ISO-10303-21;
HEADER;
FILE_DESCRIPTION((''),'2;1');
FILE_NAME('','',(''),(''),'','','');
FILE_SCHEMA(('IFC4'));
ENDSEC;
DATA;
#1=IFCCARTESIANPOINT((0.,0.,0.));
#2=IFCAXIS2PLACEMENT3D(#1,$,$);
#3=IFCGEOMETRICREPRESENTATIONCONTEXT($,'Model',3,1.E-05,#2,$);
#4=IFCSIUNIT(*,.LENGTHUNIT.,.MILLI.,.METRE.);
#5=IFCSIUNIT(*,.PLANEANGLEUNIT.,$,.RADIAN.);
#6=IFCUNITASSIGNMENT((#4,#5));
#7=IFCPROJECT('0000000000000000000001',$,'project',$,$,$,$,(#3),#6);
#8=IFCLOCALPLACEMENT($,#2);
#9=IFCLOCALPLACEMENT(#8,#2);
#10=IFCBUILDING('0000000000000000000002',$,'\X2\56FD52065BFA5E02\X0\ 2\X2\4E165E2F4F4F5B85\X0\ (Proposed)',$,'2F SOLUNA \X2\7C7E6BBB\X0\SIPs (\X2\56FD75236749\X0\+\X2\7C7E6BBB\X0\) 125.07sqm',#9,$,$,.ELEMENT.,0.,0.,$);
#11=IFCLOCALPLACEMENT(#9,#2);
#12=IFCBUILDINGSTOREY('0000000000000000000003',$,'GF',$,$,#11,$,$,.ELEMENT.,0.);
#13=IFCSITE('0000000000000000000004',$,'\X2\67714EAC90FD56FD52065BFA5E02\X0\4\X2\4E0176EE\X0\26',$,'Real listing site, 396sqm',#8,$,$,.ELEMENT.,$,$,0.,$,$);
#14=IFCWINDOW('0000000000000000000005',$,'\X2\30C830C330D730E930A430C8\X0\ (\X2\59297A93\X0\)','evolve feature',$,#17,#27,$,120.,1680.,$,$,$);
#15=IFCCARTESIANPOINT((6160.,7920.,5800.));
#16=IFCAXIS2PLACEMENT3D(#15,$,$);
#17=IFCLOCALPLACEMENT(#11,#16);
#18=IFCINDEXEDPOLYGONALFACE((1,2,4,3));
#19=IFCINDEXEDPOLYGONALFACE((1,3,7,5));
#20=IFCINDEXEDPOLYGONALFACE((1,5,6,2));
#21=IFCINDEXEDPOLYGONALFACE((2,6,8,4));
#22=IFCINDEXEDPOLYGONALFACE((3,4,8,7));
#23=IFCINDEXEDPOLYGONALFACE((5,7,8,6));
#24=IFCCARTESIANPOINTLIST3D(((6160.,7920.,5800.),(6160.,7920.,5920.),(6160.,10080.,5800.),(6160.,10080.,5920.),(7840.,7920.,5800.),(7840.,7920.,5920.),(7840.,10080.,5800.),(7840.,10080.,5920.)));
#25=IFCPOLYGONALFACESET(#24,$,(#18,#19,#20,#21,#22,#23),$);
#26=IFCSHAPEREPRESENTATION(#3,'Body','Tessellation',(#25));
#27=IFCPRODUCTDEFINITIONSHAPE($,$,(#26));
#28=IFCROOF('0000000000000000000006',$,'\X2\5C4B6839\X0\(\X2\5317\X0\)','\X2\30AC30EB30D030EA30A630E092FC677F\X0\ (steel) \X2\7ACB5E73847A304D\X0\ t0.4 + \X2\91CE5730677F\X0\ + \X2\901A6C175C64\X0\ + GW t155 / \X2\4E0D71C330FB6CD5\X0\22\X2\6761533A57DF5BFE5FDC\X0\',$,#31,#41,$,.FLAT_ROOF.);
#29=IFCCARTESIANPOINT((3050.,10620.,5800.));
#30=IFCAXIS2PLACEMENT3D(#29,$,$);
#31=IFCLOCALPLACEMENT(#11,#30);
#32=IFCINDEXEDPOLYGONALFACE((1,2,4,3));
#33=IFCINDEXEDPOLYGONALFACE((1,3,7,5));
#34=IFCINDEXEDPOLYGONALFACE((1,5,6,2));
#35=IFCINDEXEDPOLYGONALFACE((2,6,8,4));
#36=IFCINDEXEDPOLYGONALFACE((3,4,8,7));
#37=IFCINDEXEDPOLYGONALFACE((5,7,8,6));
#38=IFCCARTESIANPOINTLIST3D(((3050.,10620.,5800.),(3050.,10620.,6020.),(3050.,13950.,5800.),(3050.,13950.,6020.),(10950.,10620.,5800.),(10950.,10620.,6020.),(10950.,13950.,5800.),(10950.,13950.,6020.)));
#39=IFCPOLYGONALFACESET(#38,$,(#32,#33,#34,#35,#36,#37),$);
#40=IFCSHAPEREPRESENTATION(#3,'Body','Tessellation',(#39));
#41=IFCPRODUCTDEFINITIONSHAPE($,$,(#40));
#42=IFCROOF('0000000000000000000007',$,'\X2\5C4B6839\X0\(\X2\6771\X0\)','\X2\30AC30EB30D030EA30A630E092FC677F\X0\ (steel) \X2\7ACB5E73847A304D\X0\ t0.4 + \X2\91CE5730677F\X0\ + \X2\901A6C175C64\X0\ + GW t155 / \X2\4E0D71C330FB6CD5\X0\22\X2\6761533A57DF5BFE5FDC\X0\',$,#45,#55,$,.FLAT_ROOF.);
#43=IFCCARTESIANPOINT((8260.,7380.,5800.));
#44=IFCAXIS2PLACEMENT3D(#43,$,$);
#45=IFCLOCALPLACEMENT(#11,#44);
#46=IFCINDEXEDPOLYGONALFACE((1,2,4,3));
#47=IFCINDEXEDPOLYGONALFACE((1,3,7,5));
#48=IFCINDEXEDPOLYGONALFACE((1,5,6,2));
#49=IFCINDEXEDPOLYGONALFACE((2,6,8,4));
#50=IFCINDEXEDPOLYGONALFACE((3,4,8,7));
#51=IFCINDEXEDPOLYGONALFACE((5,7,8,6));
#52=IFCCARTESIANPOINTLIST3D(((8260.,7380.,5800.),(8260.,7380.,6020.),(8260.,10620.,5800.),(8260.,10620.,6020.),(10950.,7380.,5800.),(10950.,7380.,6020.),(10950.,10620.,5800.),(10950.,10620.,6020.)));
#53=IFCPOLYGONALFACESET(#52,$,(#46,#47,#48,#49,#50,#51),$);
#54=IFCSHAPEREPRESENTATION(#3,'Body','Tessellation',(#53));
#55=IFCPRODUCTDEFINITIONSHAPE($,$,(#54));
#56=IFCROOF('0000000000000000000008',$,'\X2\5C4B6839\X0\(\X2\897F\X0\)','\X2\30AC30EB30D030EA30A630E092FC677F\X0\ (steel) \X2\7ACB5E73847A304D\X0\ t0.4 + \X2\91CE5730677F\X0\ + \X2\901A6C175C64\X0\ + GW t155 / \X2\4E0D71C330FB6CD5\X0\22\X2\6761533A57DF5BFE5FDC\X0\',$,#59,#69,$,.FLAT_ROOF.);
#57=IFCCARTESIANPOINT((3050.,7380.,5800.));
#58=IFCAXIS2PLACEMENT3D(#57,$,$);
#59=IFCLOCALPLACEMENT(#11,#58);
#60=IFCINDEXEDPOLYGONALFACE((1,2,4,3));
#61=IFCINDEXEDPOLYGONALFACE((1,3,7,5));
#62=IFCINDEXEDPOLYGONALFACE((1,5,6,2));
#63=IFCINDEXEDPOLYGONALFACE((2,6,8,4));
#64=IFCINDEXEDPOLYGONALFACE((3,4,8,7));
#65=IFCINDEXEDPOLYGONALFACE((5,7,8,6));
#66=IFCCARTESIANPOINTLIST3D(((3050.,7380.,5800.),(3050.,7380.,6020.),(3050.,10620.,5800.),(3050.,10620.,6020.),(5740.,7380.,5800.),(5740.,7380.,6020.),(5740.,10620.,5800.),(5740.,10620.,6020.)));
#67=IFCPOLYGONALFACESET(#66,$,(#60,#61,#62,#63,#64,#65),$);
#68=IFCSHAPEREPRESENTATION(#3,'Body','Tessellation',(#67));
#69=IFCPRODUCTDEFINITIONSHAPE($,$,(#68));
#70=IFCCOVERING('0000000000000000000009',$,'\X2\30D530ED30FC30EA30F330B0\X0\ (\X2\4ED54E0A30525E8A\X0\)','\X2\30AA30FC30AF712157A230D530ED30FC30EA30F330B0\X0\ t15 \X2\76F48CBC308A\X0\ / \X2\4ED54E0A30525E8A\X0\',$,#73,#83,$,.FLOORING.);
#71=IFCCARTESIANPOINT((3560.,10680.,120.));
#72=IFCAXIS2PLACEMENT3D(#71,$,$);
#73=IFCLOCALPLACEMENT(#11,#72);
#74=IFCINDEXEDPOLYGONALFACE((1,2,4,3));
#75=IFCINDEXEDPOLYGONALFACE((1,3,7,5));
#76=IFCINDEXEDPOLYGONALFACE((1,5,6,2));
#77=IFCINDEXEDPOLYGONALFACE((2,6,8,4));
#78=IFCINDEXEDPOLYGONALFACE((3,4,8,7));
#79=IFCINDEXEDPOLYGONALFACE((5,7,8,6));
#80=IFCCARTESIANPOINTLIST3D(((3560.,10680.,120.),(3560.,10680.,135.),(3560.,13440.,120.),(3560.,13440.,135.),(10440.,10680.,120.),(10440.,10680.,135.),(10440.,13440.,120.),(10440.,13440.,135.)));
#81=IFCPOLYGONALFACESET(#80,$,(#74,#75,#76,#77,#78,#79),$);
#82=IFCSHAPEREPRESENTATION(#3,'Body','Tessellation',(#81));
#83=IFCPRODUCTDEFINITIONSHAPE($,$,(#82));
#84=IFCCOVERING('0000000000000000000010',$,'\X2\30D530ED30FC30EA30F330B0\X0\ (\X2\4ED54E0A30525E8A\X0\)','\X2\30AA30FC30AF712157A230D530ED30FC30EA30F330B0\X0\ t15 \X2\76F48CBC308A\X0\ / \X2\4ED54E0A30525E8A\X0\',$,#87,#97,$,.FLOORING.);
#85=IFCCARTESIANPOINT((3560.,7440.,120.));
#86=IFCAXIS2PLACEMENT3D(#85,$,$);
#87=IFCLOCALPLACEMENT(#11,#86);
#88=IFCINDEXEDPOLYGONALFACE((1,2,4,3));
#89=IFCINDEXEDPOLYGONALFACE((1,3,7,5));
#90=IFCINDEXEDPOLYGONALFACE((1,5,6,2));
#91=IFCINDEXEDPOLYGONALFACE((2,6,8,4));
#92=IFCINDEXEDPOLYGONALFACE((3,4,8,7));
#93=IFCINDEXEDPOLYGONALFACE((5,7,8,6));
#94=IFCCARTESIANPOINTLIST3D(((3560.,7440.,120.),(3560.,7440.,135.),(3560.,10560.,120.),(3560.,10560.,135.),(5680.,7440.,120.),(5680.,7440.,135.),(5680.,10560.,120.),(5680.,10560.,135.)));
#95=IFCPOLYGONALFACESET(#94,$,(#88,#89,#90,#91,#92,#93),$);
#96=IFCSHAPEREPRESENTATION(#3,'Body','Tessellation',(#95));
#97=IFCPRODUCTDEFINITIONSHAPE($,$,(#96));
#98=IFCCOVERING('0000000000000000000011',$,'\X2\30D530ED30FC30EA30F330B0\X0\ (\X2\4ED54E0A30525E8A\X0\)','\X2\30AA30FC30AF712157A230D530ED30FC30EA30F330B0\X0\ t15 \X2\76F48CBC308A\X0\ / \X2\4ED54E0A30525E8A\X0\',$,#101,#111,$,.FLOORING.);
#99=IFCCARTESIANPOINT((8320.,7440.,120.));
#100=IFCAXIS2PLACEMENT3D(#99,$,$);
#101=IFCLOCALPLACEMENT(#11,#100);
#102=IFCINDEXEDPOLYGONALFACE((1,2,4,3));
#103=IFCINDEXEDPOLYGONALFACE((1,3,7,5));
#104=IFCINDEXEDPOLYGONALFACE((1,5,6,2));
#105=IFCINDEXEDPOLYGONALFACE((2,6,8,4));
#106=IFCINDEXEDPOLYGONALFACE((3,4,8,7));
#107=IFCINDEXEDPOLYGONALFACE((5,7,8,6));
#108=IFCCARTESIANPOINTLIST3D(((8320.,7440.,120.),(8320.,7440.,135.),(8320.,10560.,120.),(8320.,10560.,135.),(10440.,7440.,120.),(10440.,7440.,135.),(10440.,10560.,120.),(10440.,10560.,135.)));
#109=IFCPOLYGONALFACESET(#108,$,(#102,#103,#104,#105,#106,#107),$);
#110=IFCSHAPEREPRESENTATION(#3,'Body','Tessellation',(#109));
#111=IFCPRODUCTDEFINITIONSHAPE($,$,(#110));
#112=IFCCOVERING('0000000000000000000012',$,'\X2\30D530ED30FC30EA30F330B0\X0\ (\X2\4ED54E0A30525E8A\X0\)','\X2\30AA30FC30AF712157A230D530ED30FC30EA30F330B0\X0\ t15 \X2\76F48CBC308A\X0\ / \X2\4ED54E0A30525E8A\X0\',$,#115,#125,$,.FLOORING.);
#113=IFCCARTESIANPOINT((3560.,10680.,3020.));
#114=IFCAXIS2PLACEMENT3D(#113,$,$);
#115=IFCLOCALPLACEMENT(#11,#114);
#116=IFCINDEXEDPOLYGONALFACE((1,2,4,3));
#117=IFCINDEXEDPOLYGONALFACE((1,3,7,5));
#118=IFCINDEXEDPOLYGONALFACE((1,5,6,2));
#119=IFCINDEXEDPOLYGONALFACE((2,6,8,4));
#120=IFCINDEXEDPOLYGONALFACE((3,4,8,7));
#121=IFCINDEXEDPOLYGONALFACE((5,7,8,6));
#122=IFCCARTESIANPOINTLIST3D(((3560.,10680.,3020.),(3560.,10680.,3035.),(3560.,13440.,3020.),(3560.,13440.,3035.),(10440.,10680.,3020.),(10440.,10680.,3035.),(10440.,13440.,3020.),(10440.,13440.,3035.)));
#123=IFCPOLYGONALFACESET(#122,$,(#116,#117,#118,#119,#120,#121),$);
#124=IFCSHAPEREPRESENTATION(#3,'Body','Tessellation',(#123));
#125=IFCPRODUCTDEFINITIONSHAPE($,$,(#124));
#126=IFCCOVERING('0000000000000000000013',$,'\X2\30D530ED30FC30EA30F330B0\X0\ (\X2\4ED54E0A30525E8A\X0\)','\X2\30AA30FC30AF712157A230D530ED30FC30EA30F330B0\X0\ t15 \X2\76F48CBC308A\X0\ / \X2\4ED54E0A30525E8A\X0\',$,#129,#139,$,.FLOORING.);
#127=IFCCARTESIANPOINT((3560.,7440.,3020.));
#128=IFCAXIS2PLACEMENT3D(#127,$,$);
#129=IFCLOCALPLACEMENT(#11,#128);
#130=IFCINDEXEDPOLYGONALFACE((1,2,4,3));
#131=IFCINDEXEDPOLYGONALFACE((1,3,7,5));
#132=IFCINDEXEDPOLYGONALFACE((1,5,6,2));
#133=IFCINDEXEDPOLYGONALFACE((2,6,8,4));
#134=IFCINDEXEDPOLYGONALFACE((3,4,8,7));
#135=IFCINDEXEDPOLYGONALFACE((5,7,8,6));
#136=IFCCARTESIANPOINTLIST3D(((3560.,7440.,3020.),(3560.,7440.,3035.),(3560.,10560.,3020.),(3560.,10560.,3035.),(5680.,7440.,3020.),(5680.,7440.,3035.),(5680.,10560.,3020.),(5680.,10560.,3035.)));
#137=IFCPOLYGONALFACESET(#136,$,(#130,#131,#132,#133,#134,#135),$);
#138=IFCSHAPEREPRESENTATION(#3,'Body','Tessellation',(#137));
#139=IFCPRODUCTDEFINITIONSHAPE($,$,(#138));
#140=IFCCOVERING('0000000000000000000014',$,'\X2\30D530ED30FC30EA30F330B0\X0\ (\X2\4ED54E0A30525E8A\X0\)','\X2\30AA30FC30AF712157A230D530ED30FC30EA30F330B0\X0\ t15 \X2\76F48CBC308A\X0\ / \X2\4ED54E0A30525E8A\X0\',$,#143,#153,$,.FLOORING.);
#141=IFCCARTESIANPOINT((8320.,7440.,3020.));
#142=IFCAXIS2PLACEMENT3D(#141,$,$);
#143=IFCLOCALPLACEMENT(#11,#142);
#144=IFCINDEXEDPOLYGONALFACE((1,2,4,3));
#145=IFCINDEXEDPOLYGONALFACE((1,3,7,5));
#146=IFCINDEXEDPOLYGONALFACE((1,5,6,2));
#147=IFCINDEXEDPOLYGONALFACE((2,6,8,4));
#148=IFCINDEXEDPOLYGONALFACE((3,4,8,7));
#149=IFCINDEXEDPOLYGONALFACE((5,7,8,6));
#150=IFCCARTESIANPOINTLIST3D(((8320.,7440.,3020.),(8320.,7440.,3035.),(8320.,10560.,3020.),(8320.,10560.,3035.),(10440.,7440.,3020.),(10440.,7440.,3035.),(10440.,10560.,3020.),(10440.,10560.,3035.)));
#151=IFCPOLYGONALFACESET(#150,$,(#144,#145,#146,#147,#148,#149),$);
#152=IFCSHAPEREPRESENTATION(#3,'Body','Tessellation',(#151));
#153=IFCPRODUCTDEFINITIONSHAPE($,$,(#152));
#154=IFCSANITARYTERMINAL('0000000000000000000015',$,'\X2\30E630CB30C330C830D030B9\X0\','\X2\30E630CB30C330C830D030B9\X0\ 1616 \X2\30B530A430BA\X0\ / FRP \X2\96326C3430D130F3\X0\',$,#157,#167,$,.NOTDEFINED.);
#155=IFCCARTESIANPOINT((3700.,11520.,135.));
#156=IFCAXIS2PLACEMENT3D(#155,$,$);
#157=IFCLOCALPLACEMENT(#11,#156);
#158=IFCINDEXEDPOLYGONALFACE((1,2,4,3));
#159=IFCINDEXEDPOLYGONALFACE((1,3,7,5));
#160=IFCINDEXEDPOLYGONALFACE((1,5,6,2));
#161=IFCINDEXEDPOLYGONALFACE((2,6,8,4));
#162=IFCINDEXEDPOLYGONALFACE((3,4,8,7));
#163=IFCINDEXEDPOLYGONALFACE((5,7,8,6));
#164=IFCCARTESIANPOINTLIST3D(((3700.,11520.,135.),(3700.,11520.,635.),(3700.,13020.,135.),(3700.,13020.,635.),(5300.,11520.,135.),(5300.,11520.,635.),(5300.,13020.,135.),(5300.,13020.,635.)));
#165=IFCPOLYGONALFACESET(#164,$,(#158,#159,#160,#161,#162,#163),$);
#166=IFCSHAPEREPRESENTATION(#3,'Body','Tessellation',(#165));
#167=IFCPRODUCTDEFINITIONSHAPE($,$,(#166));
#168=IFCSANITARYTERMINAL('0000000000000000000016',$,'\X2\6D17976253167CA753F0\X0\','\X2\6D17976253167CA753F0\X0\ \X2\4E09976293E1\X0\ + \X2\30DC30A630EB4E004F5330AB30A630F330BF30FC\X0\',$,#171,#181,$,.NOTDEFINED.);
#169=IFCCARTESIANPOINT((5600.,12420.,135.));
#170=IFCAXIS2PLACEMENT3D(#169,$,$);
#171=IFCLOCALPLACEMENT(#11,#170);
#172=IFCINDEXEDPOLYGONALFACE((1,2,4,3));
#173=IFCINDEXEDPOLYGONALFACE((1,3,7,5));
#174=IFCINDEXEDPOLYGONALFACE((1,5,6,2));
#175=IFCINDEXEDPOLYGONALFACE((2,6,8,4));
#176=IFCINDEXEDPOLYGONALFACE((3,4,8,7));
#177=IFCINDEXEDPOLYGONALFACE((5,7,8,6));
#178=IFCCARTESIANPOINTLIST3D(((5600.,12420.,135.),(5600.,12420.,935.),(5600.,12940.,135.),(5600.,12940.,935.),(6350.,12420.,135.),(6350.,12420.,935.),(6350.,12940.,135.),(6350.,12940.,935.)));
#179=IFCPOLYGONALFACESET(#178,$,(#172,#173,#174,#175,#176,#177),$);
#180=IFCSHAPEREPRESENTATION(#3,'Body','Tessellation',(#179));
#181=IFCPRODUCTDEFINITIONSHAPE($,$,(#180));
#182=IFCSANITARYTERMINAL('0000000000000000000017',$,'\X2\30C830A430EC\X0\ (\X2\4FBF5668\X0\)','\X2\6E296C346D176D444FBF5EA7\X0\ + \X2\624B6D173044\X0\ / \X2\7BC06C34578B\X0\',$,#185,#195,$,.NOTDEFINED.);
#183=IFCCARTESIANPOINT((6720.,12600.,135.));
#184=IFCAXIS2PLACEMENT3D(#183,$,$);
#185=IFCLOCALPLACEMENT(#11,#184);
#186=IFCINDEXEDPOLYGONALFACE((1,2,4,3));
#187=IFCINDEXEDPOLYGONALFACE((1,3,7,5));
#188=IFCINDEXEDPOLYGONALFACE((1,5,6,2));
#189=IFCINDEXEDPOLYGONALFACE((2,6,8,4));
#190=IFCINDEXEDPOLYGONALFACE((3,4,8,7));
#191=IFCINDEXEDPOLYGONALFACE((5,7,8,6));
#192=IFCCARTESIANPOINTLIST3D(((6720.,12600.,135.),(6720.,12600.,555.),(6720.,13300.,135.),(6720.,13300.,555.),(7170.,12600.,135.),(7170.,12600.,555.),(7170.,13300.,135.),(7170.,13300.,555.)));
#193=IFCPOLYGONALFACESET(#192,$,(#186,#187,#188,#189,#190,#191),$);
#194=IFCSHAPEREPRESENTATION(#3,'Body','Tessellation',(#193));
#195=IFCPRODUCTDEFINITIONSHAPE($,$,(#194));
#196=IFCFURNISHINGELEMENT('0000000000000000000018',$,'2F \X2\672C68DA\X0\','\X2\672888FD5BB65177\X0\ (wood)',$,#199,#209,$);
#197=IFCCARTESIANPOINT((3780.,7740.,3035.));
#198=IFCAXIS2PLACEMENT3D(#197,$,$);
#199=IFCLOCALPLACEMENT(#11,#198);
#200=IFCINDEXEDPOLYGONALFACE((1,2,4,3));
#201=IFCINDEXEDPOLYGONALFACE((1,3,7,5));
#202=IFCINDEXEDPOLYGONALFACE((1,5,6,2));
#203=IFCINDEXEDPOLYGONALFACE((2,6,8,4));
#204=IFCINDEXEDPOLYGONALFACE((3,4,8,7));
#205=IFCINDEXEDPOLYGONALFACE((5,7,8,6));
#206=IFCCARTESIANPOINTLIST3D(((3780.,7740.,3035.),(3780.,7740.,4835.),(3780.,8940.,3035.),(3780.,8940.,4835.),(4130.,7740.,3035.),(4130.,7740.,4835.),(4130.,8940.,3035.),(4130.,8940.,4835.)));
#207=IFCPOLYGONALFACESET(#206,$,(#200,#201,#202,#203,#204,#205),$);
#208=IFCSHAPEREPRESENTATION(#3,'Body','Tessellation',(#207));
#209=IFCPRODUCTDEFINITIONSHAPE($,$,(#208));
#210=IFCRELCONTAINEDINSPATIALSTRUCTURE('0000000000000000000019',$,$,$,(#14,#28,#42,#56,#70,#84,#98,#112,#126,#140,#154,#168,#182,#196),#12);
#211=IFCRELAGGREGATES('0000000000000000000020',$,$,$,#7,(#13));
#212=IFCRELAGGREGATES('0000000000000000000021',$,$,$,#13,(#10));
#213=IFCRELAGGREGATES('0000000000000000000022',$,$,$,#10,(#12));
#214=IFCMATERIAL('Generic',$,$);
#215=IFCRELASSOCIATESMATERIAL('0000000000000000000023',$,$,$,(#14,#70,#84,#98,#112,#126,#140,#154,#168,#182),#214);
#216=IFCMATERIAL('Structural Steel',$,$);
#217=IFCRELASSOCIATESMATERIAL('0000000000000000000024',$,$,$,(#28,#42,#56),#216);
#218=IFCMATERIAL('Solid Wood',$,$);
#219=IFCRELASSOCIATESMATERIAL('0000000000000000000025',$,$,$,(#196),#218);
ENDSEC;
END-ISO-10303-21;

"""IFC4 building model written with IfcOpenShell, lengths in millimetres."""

from ifc_helpers import new_model, si_unit, frame, frame_2d, origin, place, context, project, spatial, rectangle, extrude, material, element, save


model = new_model("IFC4")

# Units and contexts
model_context = context("Model", 3, precision=1e-05, world=origin())
ifc_project = project(units=[si_unit("LENGTHUNIT", "METRE", prefix="MILLI"), si_unit("PLANEANGLEUNIT", "RADIAN")], contexts=[model_context])

# Site, building, storey
site_placement = place(None, origin())
site = spatial("IfcSite", under=ifc_project, at=site_placement, Name="東京都国分寺市4丁目26", ObjectType="Real listing site, 396sqm", CompositionType="ELEMENT", RefElevation=0.0)
building_placement = place(site_placement, origin())
building = spatial("IfcBuilding", under=site, at=building_placement, Name="国分寺市 2世帯住宅 (Proposed)", ObjectType="2F SOLUNA 籾殻SIPs (国産杉+籾殻) 125.07sqm", CompositionType="ELEMENT", ElevationOfRefHeight=0.0, ElevationOfTerrain=0.0)
storey_placement = place(building_placement, origin())
storey = spatial("IfcBuildingStorey", under=building, at=storey_placement, Name="GF", CompositionType="ELEMENT", Elevation=0.0)

# Shared definitions
ifc_material_1 = material(Name="Solid Wood")

# Window
ifc_material_2 = material(Name="Generic")
window_1_placement = place(storey_placement, frame((6160.0, 7920.0, 5800.0)))
element("IfcWindow", 1, at=window_1_placement, inside=storey, material=ifc_material_2, Name="トップライト (天窓)", Description="evolve feature", OverallHeight=120.0, OverallWidth=1680.0, context=model_context, shape_type="SweptSolid", body=[
    extrude(rectangle(XDim=1680.0, YDim=2160.0, at=frame_2d((840.0, 1080.0))), frame((6160.0, 7920.0, 5800.0)), (0.0, 0.0, 1.0), 120.0),
])

# Roofs
ifc_material_3 = material(Name="Structural Steel")
roof_1_placement = place(storey_placement, frame((3050.0, 10620.0, 5800.0)))
element("IfcRoof", 2, at=roof_1_placement, inside=storey, material=ifc_material_3, Name="屋根(北)", Description="ガルバリウム鋼板 (steel) 立平葺き t0.4 + 野地板 + 通気層 + GW t155 / 不燃・法22条区域対応", PredefinedType="FLAT_ROOF", context=model_context, shape_type="SweptSolid", body=[
    extrude(rectangle(XDim=7900.0, YDim=3330.0, at=frame_2d((3950.0, 1665.0))), frame((3050.0, 10620.0, 5800.0)), (0.0, 0.0, 1.0), 220.0),
])
roof_2_placement = place(storey_placement, frame((8260.0, 7380.0, 5800.0)))
element("IfcRoof", 3, at=roof_2_placement, inside=storey, material=ifc_material_3, Name="屋根(東)", Description="ガルバリウム鋼板 (steel) 立平葺き t0.4 + 野地板 + 通気層 + GW t155 / 不燃・法22条区域対応", PredefinedType="FLAT_ROOF", context=model_context, shape_type="SweptSolid", body=[
    extrude(rectangle(XDim=2690.0, YDim=3240.0, at=frame_2d((1345.0, 1620.0))), frame((8260.0, 7380.0, 5800.0)), (0.0, 0.0, 1.0), 220.0),
])
roof_3_placement = place(storey_placement, frame((3050.0, 7380.0, 5800.0)))
element("IfcRoof", 4, at=roof_3_placement, inside=storey, material=ifc_material_3, Name="屋根(西)", Description="ガルバリウム鋼板 (steel) 立平葺き t0.4 + 野地板 + 通気層 + GW t155 / 不燃・法22条区域対応", PredefinedType="FLAT_ROOF", context=model_context, shape_type="SweptSolid", body=[
    extrude(rectangle(XDim=2690.0, YDim=3240.0, at=frame_2d((1345.0, 1620.0))), frame((3050.0, 7380.0, 5800.0)), (0.0, 0.0, 1.0), 220.0),
])

# Coverings
covering_1_placement = place(storey_placement, frame((3560.0, 10680.0, 120.0)))
element("IfcCovering", 5, at=covering_1_placement, inside=storey, material=ifc_material_2, Name="フローリング (仕上げ床)", Description="オーク無垢フローリング t15 直貼り / 仕上げ床", PredefinedType="FLOORING", context=model_context, shape_type="SweptSolid", body=[
    extrude(rectangle(XDim=6880.0, YDim=2760.0, at=frame_2d((3440.0, 1380.0))), frame((3560.0, 10680.0, 120.0)), (0.0, 0.0, 1.0), 15.0),
])
covering_2_placement = place(storey_placement, frame((3560.0, 7440.0, 120.0)))
element("IfcCovering", 6, at=covering_2_placement, inside=storey, material=ifc_material_2, Name="フローリング (仕上げ床)", Description="オーク無垢フローリング t15 直貼り / 仕上げ床", PredefinedType="FLOORING", context=model_context, shape_type="SweptSolid", body=[
    extrude(rectangle(XDim=2120.0, YDim=3120.0, at=frame_2d((1060.0, 1560.0))), frame((3560.0, 7440.0, 120.0)), (0.0, 0.0, 1.0), 15.0),
])
covering_3_placement = place(storey_placement, frame((8320.0, 7440.0, 120.0)))
element("IfcCovering", 7, at=covering_3_placement, inside=storey, material=ifc_material_2, Name="フローリング (仕上げ床)", Description="オーク無垢フローリング t15 直貼り / 仕上げ床", PredefinedType="FLOORING", context=model_context, shape_type="SweptSolid", body=[
    extrude(rectangle(XDim=2120.0, YDim=3120.0, at=frame_2d((1060.0, 1560.0))), frame((8320.0, 7440.0, 120.0)), (0.0, 0.0, 1.0), 15.0),
])
covering_4_placement = place(storey_placement, frame((3560.0, 10680.0, 3020.0)))
element("IfcCovering", 8, at=covering_4_placement, inside=storey, material=ifc_material_2, Name="フローリング (仕上げ床)", Description="オーク無垢フローリング t15 直貼り / 仕上げ床", PredefinedType="FLOORING", context=model_context, shape_type="SweptSolid", body=[
    extrude(rectangle(XDim=6880.0, YDim=2760.0, at=frame_2d((3440.0, 1380.0))), frame((3560.0, 10680.0, 3020.0)), (0.0, 0.0, 1.0), 15.0),
])
covering_5_placement = place(storey_placement, frame((3560.0, 7440.0, 3020.0)))
element("IfcCovering", 9, at=covering_5_placement, inside=storey, material=ifc_material_2, Name="フローリング (仕上げ床)", Description="オーク無垢フローリング t15 直貼り / 仕上げ床", PredefinedType="FLOORING", context=model_context, shape_type="SweptSolid", body=[
    extrude(rectangle(XDim=2120.0, YDim=3120.0, at=frame_2d((1060.0, 1560.0))), frame((3560.0, 7440.0, 3020.0)), (0.0, 0.0, 1.0), 15.0),
])
covering_6_placement = place(storey_placement, frame((8320.0, 7440.0, 3020.0)))
element("IfcCovering", 10, at=covering_6_placement, inside=storey, material=ifc_material_2, Name="フローリング (仕上げ床)", Description="オーク無垢フローリング t15 直貼り / 仕上げ床", PredefinedType="FLOORING", context=model_context, shape_type="SweptSolid", body=[
    extrude(rectangle(XDim=2120.0, YDim=3120.0, at=frame_2d((1060.0, 1560.0))), frame((8320.0, 7440.0, 3020.0)), (0.0, 0.0, 1.0), 15.0),
])

# Sanitary terminals
sanitary_terminal_1_placement = place(storey_placement, frame((3700.0, 11520.0, 135.0)))
element("IfcSanitaryTerminal", 11, at=sanitary_terminal_1_placement, inside=storey, material=ifc_material_2, Name="ユニットバス", Description="ユニットバス 1616 サイズ / FRP 防水パン", PredefinedType="NOTDEFINED", context=model_context, shape_type="SweptSolid", body=[
    extrude(rectangle(XDim=1600.0, YDim=1500.0, at=frame_2d((800.0, 750.0))), frame((3700.0, 11520.0, 135.0)), (0.0, 0.0, 1.0), 500.0),
])
sanitary_terminal_2_placement = place(storey_placement, frame((5600.0, 12420.0, 135.0)))
element("IfcSanitaryTerminal", 12, at=sanitary_terminal_2_placement, inside=storey, material=ifc_material_2, Name="洗面化粧台", Description="洗面化粧台 三面鏡 + ボウル一体カウンター", PredefinedType="NOTDEFINED", context=model_context, shape_type="SweptSolid", body=[
    extrude(rectangle(XDim=750.0, YDim=520.0, at=frame_2d((375.0, 260.0))), frame((5600.0, 12420.0, 135.0)), (0.0, 0.0, 1.0), 800.0),
])
sanitary_terminal_3_placement = place(storey_placement, frame((6720.0, 12600.0, 135.0)))
element("IfcSanitaryTerminal", 13, at=sanitary_terminal_3_placement, inside=storey, material=ifc_material_2, Name="トイレ (便器)", Description="温水洗浄便座 + 手洗い / 節水型", PredefinedType="NOTDEFINED", context=model_context, shape_type="SweptSolid", body=[
    extrude(rectangle(XDim=450.0, YDim=700.0, at=frame_2d((225.0, 350.0))), frame((6720.0, 12600.0, 135.0)), (0.0, 0.0, 1.0), 420.0),
])

# Furnishing element
furnishing_placement = place(storey_placement, frame((3780.0, 7740.0, 3035.0)))
element("IfcFurnishingElement", 14, at=furnishing_placement, inside=storey, material=ifc_material_1, Name="2F 本棚", Description="木製家具 (wood)", context=model_context, shape_type="SweptSolid", body=[
    extrude(rectangle(XDim=350.0, YDim=1200.0, at=frame_2d((175.0, 600.0))), frame((3780.0, 7740.0, 3035.0)), (0.0, 0.0, 1.0), 1800.0),
])

save(model, "model.ifc")
